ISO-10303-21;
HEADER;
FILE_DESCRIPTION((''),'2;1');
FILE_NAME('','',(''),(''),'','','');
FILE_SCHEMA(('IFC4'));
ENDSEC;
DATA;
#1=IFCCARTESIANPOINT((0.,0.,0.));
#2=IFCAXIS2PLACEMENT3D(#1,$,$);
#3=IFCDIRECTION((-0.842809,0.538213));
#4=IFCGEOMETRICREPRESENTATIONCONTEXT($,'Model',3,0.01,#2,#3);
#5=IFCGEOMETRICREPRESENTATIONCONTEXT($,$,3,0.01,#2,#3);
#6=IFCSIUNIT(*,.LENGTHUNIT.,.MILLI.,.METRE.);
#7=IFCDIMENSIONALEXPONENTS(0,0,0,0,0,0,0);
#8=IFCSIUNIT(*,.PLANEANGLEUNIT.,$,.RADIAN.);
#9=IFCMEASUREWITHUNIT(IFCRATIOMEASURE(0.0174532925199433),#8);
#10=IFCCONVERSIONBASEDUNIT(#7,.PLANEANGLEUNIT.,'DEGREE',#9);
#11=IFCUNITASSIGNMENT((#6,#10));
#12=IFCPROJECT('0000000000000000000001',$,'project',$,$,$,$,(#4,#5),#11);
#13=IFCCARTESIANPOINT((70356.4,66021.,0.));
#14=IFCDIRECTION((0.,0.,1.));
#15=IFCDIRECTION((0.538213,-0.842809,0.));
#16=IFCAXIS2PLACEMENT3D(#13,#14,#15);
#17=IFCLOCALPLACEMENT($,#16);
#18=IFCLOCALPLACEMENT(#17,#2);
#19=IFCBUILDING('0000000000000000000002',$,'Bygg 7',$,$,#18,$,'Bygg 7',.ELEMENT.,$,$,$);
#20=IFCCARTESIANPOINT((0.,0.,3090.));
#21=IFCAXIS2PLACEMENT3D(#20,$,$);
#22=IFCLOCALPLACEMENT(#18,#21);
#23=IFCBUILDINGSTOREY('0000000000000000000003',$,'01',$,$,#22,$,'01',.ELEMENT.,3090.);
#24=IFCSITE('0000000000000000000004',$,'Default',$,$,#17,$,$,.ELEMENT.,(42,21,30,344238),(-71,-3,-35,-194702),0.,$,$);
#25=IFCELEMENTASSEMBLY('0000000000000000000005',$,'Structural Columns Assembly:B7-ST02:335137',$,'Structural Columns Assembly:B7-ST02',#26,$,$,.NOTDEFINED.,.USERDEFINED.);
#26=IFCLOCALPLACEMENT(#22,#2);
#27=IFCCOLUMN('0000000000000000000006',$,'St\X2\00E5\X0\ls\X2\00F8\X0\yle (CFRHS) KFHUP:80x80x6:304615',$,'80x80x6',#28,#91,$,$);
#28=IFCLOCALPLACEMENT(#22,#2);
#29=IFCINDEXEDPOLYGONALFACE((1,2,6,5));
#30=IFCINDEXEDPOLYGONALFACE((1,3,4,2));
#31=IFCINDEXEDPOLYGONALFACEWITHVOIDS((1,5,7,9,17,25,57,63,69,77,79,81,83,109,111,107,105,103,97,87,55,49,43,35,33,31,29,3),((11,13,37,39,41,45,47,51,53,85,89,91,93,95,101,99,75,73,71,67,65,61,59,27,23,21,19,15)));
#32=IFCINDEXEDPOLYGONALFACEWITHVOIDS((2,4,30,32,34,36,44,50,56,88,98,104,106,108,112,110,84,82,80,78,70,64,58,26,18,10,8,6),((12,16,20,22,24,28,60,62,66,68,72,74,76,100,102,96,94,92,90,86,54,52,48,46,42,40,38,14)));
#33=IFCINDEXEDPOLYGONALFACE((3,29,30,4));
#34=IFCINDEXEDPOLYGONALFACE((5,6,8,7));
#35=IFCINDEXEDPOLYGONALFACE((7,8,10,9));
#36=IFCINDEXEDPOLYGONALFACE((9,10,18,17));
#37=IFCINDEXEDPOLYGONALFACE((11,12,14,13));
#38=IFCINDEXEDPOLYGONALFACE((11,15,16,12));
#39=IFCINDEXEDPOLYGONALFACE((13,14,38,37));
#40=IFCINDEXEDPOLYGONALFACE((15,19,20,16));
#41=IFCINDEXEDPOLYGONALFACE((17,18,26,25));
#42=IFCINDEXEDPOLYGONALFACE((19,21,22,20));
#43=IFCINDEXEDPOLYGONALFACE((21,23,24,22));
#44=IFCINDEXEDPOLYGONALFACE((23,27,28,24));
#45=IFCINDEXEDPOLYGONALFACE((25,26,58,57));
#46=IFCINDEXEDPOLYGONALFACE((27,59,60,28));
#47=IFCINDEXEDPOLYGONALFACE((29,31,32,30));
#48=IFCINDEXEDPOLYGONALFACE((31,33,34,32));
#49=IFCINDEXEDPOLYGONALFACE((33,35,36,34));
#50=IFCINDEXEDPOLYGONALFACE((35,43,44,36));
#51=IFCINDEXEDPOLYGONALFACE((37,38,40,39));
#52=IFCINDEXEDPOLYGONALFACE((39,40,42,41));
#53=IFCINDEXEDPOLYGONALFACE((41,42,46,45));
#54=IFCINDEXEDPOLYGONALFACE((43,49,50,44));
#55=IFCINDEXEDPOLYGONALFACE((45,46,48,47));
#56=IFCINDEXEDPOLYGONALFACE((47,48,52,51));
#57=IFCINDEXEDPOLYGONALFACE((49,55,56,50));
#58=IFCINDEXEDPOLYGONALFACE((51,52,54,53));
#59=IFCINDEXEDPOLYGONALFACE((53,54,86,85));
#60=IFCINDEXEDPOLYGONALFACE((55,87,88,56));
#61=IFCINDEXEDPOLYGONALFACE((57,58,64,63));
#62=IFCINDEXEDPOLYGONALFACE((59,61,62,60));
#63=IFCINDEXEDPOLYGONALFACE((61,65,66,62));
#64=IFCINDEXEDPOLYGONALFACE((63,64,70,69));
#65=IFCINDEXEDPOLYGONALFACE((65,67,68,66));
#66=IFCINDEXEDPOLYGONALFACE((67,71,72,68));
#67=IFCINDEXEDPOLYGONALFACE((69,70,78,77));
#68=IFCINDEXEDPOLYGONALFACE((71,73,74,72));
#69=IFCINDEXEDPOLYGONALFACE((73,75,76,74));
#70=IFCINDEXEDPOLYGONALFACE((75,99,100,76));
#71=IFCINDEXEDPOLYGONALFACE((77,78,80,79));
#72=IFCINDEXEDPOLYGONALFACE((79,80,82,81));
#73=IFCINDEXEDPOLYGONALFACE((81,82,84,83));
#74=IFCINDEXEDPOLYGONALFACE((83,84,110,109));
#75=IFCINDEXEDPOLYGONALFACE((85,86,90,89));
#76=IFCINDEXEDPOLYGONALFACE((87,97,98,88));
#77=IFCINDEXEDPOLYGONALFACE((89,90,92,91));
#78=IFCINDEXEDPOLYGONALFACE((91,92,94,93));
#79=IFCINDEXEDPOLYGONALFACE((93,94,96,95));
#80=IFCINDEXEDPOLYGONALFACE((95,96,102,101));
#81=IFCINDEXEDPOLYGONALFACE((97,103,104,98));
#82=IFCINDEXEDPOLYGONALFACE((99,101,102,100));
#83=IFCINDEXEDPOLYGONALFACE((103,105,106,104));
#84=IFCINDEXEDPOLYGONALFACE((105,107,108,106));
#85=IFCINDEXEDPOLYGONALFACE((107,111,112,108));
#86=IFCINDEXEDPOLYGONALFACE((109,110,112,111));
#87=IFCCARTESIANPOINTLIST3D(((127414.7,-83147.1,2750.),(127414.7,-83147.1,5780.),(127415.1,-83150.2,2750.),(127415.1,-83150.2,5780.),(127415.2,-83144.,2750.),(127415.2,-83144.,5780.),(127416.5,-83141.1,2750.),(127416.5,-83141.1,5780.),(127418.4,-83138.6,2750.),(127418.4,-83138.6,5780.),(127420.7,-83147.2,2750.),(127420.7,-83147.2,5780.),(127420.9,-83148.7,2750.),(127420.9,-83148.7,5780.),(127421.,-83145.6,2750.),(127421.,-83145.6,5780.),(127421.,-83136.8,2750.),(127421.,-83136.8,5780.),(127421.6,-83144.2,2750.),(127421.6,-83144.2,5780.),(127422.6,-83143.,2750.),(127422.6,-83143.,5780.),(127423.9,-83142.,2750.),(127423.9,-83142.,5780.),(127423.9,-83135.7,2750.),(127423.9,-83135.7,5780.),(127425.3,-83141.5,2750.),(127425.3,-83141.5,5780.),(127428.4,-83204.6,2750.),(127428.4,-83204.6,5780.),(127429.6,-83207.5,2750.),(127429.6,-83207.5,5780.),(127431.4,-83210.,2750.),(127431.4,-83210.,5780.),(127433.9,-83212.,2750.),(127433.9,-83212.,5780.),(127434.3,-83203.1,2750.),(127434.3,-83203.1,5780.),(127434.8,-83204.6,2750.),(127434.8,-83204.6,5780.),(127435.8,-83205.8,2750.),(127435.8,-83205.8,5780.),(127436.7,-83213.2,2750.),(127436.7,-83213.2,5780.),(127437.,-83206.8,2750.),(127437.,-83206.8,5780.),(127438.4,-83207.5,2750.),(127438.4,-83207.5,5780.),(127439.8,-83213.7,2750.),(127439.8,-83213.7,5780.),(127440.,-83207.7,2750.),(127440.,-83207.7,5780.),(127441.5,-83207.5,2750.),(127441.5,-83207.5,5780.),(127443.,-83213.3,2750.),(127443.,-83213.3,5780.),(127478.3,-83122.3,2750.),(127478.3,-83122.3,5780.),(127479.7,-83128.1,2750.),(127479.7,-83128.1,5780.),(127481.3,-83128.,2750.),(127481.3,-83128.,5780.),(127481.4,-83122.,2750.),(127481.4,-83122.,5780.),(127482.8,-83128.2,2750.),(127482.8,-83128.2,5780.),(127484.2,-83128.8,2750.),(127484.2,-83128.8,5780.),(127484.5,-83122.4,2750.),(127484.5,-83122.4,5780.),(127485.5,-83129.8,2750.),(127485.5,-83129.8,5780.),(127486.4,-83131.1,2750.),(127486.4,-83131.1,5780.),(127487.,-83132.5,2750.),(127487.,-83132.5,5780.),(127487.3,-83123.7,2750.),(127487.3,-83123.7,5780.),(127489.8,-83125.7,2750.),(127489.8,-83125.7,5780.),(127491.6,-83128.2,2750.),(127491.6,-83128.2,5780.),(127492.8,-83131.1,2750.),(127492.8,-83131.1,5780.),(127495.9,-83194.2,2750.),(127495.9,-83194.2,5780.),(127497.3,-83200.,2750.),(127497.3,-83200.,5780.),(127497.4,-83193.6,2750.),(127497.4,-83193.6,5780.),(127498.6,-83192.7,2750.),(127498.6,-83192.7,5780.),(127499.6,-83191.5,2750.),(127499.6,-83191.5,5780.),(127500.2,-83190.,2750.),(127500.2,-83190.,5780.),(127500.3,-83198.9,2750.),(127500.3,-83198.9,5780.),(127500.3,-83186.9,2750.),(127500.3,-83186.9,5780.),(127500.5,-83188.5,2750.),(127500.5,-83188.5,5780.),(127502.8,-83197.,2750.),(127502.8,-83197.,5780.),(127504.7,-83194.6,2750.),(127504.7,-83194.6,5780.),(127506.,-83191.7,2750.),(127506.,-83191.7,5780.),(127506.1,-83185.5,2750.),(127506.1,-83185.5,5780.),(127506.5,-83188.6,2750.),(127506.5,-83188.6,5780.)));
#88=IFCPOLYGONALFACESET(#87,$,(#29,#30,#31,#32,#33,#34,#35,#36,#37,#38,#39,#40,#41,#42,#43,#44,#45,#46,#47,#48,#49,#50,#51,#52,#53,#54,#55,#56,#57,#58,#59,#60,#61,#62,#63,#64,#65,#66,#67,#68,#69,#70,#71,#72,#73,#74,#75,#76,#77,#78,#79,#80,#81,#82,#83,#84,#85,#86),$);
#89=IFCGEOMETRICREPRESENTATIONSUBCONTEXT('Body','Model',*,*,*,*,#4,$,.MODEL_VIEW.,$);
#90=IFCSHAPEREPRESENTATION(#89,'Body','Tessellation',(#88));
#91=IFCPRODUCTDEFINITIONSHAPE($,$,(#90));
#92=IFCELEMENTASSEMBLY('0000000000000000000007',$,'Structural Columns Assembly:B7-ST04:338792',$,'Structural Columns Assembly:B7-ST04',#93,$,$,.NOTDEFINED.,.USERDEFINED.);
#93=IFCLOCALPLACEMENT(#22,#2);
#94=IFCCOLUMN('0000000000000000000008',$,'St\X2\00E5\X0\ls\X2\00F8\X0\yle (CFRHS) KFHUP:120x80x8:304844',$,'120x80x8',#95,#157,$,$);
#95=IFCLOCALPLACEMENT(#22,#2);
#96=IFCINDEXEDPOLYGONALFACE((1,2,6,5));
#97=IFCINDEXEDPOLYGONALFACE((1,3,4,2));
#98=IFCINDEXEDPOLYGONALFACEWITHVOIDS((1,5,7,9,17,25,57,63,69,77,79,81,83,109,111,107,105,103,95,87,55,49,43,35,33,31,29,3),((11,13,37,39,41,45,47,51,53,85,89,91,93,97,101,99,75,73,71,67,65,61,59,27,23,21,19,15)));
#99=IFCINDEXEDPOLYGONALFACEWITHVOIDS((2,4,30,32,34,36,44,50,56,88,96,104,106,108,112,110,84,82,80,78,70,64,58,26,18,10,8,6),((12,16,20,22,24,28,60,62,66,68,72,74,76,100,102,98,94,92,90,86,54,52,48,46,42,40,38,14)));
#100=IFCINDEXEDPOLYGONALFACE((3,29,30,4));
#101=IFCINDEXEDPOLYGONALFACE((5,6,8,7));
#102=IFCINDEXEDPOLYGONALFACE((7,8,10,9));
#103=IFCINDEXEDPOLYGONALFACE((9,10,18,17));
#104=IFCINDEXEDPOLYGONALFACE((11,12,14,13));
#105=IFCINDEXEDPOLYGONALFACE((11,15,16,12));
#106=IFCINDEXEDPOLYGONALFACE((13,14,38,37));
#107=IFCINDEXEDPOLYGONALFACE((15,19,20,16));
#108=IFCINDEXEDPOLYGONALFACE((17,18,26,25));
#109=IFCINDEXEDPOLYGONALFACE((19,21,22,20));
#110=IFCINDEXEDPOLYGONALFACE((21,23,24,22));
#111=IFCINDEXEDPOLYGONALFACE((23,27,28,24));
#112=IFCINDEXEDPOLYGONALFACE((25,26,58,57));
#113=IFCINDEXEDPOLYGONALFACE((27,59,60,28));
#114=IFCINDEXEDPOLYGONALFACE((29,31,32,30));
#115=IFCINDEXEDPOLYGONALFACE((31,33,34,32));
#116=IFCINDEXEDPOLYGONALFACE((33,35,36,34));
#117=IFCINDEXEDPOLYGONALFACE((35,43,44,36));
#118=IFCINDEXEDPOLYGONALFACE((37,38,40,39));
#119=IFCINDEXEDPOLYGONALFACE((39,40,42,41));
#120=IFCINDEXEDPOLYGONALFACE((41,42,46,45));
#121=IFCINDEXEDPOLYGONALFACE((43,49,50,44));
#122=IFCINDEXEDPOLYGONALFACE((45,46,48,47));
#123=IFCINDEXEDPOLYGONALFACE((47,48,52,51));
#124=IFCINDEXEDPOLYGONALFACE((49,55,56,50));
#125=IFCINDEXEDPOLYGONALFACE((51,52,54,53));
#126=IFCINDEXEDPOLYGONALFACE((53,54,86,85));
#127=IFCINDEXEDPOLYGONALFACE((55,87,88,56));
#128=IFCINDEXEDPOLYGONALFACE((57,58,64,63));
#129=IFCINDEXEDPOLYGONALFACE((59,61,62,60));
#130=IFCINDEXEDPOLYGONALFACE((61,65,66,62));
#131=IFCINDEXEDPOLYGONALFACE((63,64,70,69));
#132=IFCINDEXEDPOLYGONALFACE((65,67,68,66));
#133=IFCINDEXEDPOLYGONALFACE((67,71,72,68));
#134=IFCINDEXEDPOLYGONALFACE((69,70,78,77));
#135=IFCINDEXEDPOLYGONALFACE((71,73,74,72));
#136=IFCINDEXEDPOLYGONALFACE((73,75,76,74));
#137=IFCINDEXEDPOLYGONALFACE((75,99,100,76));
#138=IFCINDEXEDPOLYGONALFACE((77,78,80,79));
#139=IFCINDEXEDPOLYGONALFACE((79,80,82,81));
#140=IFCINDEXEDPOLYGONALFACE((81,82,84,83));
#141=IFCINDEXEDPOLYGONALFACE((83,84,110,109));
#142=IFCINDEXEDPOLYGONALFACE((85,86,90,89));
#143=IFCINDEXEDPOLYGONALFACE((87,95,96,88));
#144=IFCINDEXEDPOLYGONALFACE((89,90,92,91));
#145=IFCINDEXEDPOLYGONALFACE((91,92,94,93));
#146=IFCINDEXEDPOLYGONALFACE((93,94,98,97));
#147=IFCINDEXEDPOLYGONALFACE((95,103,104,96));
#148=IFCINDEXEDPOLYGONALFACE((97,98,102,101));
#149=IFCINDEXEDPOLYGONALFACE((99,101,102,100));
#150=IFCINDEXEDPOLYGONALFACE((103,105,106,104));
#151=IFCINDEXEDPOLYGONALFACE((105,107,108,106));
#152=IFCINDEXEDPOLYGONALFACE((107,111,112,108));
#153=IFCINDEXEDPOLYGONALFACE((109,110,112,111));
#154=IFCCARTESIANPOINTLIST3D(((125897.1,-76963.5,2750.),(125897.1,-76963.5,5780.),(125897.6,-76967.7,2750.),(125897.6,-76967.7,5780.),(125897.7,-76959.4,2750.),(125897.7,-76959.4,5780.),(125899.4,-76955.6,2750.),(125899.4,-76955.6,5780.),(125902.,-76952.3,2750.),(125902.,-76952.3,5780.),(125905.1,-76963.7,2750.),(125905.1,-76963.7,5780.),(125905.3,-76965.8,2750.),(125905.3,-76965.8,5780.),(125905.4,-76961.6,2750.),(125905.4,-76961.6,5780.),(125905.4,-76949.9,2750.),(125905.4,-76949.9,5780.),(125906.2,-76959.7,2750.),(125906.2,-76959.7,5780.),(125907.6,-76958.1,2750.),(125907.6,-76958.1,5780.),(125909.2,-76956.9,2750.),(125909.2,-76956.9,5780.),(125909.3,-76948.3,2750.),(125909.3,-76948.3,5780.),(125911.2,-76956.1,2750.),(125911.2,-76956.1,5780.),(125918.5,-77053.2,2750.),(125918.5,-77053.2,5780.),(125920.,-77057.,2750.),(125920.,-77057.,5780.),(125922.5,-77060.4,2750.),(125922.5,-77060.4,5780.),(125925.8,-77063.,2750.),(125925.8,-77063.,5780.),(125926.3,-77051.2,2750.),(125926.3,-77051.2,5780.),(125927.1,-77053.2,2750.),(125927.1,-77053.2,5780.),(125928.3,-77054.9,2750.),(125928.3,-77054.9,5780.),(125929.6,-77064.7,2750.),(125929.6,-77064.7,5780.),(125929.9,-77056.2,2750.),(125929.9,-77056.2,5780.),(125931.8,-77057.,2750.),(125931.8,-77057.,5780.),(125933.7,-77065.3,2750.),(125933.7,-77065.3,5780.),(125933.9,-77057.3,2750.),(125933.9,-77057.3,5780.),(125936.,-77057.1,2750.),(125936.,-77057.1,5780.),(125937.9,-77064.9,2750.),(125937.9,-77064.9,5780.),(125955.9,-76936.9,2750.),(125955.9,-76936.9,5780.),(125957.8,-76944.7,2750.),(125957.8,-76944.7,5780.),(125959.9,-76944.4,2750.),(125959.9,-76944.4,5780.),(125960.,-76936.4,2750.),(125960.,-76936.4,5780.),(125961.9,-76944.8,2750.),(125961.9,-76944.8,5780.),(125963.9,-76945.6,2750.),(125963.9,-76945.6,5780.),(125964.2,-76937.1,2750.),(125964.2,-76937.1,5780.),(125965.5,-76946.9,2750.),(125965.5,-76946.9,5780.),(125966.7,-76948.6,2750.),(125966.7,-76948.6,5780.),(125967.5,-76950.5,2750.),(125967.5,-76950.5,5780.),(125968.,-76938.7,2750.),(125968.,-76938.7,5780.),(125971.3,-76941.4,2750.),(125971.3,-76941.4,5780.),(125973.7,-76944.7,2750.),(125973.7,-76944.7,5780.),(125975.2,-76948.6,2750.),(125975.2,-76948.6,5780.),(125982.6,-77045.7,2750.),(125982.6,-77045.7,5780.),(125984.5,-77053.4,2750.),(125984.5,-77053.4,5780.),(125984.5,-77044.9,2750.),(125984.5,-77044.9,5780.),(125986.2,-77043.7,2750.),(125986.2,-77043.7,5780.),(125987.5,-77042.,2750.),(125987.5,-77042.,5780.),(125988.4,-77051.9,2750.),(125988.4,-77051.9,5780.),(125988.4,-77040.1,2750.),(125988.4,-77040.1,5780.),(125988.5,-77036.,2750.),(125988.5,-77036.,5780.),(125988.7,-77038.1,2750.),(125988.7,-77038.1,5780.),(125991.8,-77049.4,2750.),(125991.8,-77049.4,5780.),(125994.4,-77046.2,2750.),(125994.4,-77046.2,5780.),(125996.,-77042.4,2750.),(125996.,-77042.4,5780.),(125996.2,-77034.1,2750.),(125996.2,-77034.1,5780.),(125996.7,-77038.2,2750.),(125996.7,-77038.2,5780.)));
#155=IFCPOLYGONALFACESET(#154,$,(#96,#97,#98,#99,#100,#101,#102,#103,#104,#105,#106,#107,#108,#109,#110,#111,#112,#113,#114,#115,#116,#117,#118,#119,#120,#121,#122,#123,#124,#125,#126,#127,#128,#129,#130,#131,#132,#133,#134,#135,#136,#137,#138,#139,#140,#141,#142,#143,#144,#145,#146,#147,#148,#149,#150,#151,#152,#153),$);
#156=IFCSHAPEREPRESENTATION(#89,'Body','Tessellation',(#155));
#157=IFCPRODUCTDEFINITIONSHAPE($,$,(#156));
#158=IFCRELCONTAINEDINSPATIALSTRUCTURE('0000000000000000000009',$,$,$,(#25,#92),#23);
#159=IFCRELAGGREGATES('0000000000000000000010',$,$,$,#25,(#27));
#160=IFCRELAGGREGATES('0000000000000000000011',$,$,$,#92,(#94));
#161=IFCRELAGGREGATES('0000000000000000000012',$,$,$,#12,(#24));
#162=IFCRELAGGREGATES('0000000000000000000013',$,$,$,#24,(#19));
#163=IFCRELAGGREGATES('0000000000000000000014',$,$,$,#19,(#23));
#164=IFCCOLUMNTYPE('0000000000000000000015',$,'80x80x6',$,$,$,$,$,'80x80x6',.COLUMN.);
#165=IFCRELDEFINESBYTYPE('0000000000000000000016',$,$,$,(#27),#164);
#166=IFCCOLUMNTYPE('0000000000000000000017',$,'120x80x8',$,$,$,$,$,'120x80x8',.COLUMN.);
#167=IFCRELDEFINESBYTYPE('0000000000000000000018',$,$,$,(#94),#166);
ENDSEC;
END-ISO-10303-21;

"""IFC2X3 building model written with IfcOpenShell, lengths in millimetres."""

from ifc_helpers import new_model, entity, si_unit, converted_unit, direction, frame, frame_2d, origin, place, context, subcontext, project, spatial, polyline, circle_curve, parameter, trimmed, segment, composite_curve, outline, extrude, source, transform, mapped, type_object, type_shapes, element, aggregate, save


model = new_model("IFC2X3")

# Units and contexts
model_context = context("Model", 3, precision=0.01, world=origin(), true_north=direction((-0.842809, 0.538213)))
context_of_model = context(None, 3, precision=0.01, world=origin(), true_north=direction((-0.842809, 0.538213)))
body_context = subcontext(model_context, "Body", "Model", "MODEL_VIEW")
ifc_project = project(units=[si_unit("LENGTHUNIT", "METRE", prefix="MILLI"), converted_unit("PLANEANGLEUNIT", "DEGREE", entity("IfcRatioMeasure", 0.0174532925199433), si_unit("PLANEANGLEUNIT", "RADIAN"), dimensions=[0, 0, 0, 0, 0, 0, 0])], contexts=[model_context, context_of_model])

# Site, building, storey
site_placement = place(None, frame((70356.4, 66021.0, 0.0), z_axis=(0.0, 0.0, 1.0), x_axis=(0.538213, -0.842809, 0.0)))
site = spatial("IfcSite", under=ifc_project, at=site_placement, Name="Default", CompositionType="ELEMENT", RefLatitude=(42, 21, 30, 344238), RefLongitude=(-71, -3, -35, -194702), RefElevation=0.0)
building_placement = place(site_placement, origin())
building = spatial("IfcBuilding", under=site, at=building_placement, Name="Bygg 7", LongName="Bygg 7", CompositionType="ELEMENT")
storey_placement = place(building_placement, frame((0.0, 0.0, 3090.0)))
storey = spatial("IfcBuildingStorey", under=building, at=storey_placement, Name="01", LongName="01", CompositionType="ELEMENT", Elevation=3090.0)

# Element assemblies, columns
assembly_1_placement = place(storey_placement, origin())
assembly_1 = element("IfcElementAssembly", 1, at=assembly_1_placement, inside=storey, Name="Structural Columns Assembly:B7-ST02:335137", ObjectType="Structural Columns Assembly:B7-ST02", AssemblyPlace="NOTDEFINED", PredefinedType="USERDEFINED")
column_type_1 = type_object("IfcColumnType", Name="80x80x6", ElementType="80x80x6", PredefinedType="COLUMN")
shared_shape_1 = source(origin(), body_context, "Body", "SweptSolid", [
    extrude(outline(composite_curve([segment(trimmed(circle_curve(frame_2d((-28.0, 28.0), x_axis=(1.0, 0.0)), 12.0), [parameter(90.0)], [parameter(180.0)], True, "PARAMETER"), True, "CONTINUOUS"), segment(polyline([(-40.0, 28.0), (-40.0, -28.0)]), True, "CONTINUOUS"), segment(trimmed(circle_curve(frame_2d((-28.0, -28.0), x_axis=(1.0, 0.0)), 12.0), [parameter(180.0)], [parameter(270.0)], True, "PARAMETER"), True, "CONTINUOUS"), segment(polyline([(-28.0, -40.0), (28.0, -40.0)]), True, "CONTINUOUS"), segment(trimmed(circle_curve(frame_2d((28.0, -28.0), x_axis=(1.0, 0.0)), 12.0), [parameter(270.0)], [parameter(0.0)], True, "PARAMETER"), True, "CONTINUOUS"), segment(polyline([(40.0, -28.0), (40.0, 28.0)]), True, "CONTINUOUS"), segment(trimmed(circle_curve(frame_2d((28.0, 28.0), x_axis=(1.0, 0.0)), 12.0), [parameter(0.0)], [parameter(90.0)], True, "PARAMETER"), True, "CONTINUOUS"), segment(polyline([(28.0, 40.0), (-28.0, 40.0)]), True, "CONTINUOUS")], self_intersect=False), holes=[composite_curve([segment(polyline([(-28.0, 34.0), (28.0, 34.0)]), True, "CONTINUOUS"), segment(trimmed(circle_curve(frame_2d((28.0, 28.0), x_axis=(1.0, 0.0)), 6.0), [parameter(360.0)], [parameter(90.0)], True, "PARAMETER"), False, "CONTINUOUS"), segment(polyline([(34.0, 28.0), (34.0, -28.0)]), True, "CONTINUOUS"), segment(trimmed(circle_curve(frame_2d((28.0, -28.0), x_axis=(1.0, 0.0)), 6.0), [parameter(270.0)], [parameter(360.0)], True, "PARAMETER"), False, "CONTINUOUS"), segment(polyline([(28.0, -34.0), (-28.0, -34.0)]), True, "CONTINUOUS"), segment(trimmed(circle_curve(frame_2d((-28.0, -28.0), x_axis=(1.0, 0.0)), 6.0), [parameter(180.0)], [parameter(270.0)], True, "PARAMETER"), False, "CONTINUOUS"), segment(polyline([(-34.0, -28.0), (-34.0, 28.0)]), True, "CONTINUOUS"), segment(trimmed(circle_curve(frame_2d((-28.0, 28.0), x_axis=(1.0, 0.0)), 6.0), [parameter(90.0)], [parameter(180.0)], True, "PARAMETER"), False, "CONTINUOUS")], self_intersect=False)]), frame((47.5, 47.5, 0.0), z_axis=(0.0, 0.0, 1.0), x_axis=(-0.971172, -0.238381, 0.0)), (0.0, 0.0, 1.0), 3030.0),
])
type_shapes(column_type_1, [shared_shape_1])
column_1_placement = place(assembly_1_placement, frame((127413.1, -83215.3, 2750.0)))
column_1 = element("IfcColumn", 2, at=column_1_placement, type_object=column_type_1, Name="Stålsøyle (CFRHS) KFHUP:80x80x6:304615", ObjectType="80x80x6", context=body_context, shape_type="MappedRepresentation", body=[
    mapped(shared_shape_1, transform((0.0, 0.0, 0.0), scale=1.0)),
])
aggregate(assembly_1, [column_1])
assembly_2_placement = place(storey_placement, origin())
assembly_2 = element("IfcElementAssembly", 3, at=assembly_2_placement, inside=storey, Name="Structural Columns Assembly:B7-ST04:338792", ObjectType="Structural Columns Assembly:B7-ST04", AssemblyPlace="NOTDEFINED", PredefinedType="USERDEFINED")
column_type_2 = type_object("IfcColumnType", Name="120x80x8", ElementType="120x80x8", PredefinedType="COLUMN")
shared_shape_2 = source(origin(), body_context, "Body", "SweptSolid", [
    extrude(outline(composite_curve([segment(trimmed(circle_curve(frame_2d((-24.0, 44.0), x_axis=(1.0, 0.0)), 16.0), [parameter(90.0)], [parameter(180.0)], True, "PARAMETER"), True, "CONTINUOUS"), segment(polyline([(-40.0, 44.0), (-40.0, -44.0)]), True, "CONTINUOUS"), segment(trimmed(circle_curve(frame_2d((-24.0, -44.0), x_axis=(1.0, 0.0)), 16.0), [parameter(180.0)], [parameter(270.0)], True, "PARAMETER"), True, "CONTINUOUS"), segment(polyline([(-24.0, -60.0), (24.0, -60.0)]), True, "CONTINUOUS"), segment(trimmed(circle_curve(frame_2d((24.0, -44.0), x_axis=(1.0, 0.0)), 16.0), [parameter(270.0)], [parameter(0.0)], True, "PARAMETER"), True, "CONTINUOUS"), segment(polyline([(40.0, -44.0), (40.0, 44.0)]), True, "CONTINUOUS"), segment(trimmed(circle_curve(frame_2d((24.0, 44.0), x_axis=(1.0, 0.0)), 16.0), [parameter(0.0)], [parameter(90.0)], True, "PARAMETER"), True, "CONTINUOUS"), segment(polyline([(24.0, 60.0), (-24.0, 60.0)]), True, "CONTINUOUS")], self_intersect=False), holes=[composite_curve([segment(polyline([(-24.0, 52.0), (24.0, 52.0)]), True, "CONTINUOUS"), segment(trimmed(circle_curve(frame_2d((24.0, 44.0), x_axis=(1.0, 0.0)), 8.0), [parameter(360.0)], [parameter(90.0)], True, "PARAMETER"), False, "CONTINUOUS"), segment(polyline([(32.0, 44.0), (32.0, -44.0)]), True, "CONTINUOUS"), segment(trimmed(circle_curve(frame_2d((24.0, -44.0), x_axis=(1.0, 0.0)), 8.0), [parameter(270.0)], [parameter(360.0)], True, "PARAMETER"), False, "CONTINUOUS"), segment(polyline([(24.0, -52.0), (-24.0, -52.0)]), True, "CONTINUOUS"), segment(trimmed(circle_curve(frame_2d((-24.0, -44.0), x_axis=(1.0, 0.0)), 8.0), [parameter(180.0)], [parameter(270.0)], True, "PARAMETER"), False, "CONTINUOUS"), segment(polyline([(-32.0, -44.0), (-32.0, 44.0)]), True, "CONTINUOUS"), segment(trimmed(circle_curve(frame_2d((-24.0, 44.0), x_axis=(1.0, 0.0)), 8.0), [parameter(90.0)], [parameter(180.0)], True, "PARAMETER"), False, "CONTINUOUS")], self_intersect=False)]), frame((51.4, 66.0, 0.0), z_axis=(0.0, 0.0, 1.0), x_axis=(-0.971172, -0.238381, 0.0)), (0.0, 0.0, 1.0), 3030.0),
])
type_shapes(column_type_2, [shared_shape_2])
column_2_placement = place(assembly_2_placement, frame((125895.5, -77066.9, 2750.0)))
column_2 = element("IfcColumn", 4, at=column_2_placement, type_object=column_type_2, Name="Stålsøyle (CFRHS) KFHUP:120x80x8:304844", ObjectType="120x80x8", context=body_context, shape_type="MappedRepresentation", body=[
    mapped(shared_shape_2, transform((0.0, 0.0, 0.0), scale=1.0)),
])
aggregate(assembly_2, [column_2])

save(model, "model.ifc")
